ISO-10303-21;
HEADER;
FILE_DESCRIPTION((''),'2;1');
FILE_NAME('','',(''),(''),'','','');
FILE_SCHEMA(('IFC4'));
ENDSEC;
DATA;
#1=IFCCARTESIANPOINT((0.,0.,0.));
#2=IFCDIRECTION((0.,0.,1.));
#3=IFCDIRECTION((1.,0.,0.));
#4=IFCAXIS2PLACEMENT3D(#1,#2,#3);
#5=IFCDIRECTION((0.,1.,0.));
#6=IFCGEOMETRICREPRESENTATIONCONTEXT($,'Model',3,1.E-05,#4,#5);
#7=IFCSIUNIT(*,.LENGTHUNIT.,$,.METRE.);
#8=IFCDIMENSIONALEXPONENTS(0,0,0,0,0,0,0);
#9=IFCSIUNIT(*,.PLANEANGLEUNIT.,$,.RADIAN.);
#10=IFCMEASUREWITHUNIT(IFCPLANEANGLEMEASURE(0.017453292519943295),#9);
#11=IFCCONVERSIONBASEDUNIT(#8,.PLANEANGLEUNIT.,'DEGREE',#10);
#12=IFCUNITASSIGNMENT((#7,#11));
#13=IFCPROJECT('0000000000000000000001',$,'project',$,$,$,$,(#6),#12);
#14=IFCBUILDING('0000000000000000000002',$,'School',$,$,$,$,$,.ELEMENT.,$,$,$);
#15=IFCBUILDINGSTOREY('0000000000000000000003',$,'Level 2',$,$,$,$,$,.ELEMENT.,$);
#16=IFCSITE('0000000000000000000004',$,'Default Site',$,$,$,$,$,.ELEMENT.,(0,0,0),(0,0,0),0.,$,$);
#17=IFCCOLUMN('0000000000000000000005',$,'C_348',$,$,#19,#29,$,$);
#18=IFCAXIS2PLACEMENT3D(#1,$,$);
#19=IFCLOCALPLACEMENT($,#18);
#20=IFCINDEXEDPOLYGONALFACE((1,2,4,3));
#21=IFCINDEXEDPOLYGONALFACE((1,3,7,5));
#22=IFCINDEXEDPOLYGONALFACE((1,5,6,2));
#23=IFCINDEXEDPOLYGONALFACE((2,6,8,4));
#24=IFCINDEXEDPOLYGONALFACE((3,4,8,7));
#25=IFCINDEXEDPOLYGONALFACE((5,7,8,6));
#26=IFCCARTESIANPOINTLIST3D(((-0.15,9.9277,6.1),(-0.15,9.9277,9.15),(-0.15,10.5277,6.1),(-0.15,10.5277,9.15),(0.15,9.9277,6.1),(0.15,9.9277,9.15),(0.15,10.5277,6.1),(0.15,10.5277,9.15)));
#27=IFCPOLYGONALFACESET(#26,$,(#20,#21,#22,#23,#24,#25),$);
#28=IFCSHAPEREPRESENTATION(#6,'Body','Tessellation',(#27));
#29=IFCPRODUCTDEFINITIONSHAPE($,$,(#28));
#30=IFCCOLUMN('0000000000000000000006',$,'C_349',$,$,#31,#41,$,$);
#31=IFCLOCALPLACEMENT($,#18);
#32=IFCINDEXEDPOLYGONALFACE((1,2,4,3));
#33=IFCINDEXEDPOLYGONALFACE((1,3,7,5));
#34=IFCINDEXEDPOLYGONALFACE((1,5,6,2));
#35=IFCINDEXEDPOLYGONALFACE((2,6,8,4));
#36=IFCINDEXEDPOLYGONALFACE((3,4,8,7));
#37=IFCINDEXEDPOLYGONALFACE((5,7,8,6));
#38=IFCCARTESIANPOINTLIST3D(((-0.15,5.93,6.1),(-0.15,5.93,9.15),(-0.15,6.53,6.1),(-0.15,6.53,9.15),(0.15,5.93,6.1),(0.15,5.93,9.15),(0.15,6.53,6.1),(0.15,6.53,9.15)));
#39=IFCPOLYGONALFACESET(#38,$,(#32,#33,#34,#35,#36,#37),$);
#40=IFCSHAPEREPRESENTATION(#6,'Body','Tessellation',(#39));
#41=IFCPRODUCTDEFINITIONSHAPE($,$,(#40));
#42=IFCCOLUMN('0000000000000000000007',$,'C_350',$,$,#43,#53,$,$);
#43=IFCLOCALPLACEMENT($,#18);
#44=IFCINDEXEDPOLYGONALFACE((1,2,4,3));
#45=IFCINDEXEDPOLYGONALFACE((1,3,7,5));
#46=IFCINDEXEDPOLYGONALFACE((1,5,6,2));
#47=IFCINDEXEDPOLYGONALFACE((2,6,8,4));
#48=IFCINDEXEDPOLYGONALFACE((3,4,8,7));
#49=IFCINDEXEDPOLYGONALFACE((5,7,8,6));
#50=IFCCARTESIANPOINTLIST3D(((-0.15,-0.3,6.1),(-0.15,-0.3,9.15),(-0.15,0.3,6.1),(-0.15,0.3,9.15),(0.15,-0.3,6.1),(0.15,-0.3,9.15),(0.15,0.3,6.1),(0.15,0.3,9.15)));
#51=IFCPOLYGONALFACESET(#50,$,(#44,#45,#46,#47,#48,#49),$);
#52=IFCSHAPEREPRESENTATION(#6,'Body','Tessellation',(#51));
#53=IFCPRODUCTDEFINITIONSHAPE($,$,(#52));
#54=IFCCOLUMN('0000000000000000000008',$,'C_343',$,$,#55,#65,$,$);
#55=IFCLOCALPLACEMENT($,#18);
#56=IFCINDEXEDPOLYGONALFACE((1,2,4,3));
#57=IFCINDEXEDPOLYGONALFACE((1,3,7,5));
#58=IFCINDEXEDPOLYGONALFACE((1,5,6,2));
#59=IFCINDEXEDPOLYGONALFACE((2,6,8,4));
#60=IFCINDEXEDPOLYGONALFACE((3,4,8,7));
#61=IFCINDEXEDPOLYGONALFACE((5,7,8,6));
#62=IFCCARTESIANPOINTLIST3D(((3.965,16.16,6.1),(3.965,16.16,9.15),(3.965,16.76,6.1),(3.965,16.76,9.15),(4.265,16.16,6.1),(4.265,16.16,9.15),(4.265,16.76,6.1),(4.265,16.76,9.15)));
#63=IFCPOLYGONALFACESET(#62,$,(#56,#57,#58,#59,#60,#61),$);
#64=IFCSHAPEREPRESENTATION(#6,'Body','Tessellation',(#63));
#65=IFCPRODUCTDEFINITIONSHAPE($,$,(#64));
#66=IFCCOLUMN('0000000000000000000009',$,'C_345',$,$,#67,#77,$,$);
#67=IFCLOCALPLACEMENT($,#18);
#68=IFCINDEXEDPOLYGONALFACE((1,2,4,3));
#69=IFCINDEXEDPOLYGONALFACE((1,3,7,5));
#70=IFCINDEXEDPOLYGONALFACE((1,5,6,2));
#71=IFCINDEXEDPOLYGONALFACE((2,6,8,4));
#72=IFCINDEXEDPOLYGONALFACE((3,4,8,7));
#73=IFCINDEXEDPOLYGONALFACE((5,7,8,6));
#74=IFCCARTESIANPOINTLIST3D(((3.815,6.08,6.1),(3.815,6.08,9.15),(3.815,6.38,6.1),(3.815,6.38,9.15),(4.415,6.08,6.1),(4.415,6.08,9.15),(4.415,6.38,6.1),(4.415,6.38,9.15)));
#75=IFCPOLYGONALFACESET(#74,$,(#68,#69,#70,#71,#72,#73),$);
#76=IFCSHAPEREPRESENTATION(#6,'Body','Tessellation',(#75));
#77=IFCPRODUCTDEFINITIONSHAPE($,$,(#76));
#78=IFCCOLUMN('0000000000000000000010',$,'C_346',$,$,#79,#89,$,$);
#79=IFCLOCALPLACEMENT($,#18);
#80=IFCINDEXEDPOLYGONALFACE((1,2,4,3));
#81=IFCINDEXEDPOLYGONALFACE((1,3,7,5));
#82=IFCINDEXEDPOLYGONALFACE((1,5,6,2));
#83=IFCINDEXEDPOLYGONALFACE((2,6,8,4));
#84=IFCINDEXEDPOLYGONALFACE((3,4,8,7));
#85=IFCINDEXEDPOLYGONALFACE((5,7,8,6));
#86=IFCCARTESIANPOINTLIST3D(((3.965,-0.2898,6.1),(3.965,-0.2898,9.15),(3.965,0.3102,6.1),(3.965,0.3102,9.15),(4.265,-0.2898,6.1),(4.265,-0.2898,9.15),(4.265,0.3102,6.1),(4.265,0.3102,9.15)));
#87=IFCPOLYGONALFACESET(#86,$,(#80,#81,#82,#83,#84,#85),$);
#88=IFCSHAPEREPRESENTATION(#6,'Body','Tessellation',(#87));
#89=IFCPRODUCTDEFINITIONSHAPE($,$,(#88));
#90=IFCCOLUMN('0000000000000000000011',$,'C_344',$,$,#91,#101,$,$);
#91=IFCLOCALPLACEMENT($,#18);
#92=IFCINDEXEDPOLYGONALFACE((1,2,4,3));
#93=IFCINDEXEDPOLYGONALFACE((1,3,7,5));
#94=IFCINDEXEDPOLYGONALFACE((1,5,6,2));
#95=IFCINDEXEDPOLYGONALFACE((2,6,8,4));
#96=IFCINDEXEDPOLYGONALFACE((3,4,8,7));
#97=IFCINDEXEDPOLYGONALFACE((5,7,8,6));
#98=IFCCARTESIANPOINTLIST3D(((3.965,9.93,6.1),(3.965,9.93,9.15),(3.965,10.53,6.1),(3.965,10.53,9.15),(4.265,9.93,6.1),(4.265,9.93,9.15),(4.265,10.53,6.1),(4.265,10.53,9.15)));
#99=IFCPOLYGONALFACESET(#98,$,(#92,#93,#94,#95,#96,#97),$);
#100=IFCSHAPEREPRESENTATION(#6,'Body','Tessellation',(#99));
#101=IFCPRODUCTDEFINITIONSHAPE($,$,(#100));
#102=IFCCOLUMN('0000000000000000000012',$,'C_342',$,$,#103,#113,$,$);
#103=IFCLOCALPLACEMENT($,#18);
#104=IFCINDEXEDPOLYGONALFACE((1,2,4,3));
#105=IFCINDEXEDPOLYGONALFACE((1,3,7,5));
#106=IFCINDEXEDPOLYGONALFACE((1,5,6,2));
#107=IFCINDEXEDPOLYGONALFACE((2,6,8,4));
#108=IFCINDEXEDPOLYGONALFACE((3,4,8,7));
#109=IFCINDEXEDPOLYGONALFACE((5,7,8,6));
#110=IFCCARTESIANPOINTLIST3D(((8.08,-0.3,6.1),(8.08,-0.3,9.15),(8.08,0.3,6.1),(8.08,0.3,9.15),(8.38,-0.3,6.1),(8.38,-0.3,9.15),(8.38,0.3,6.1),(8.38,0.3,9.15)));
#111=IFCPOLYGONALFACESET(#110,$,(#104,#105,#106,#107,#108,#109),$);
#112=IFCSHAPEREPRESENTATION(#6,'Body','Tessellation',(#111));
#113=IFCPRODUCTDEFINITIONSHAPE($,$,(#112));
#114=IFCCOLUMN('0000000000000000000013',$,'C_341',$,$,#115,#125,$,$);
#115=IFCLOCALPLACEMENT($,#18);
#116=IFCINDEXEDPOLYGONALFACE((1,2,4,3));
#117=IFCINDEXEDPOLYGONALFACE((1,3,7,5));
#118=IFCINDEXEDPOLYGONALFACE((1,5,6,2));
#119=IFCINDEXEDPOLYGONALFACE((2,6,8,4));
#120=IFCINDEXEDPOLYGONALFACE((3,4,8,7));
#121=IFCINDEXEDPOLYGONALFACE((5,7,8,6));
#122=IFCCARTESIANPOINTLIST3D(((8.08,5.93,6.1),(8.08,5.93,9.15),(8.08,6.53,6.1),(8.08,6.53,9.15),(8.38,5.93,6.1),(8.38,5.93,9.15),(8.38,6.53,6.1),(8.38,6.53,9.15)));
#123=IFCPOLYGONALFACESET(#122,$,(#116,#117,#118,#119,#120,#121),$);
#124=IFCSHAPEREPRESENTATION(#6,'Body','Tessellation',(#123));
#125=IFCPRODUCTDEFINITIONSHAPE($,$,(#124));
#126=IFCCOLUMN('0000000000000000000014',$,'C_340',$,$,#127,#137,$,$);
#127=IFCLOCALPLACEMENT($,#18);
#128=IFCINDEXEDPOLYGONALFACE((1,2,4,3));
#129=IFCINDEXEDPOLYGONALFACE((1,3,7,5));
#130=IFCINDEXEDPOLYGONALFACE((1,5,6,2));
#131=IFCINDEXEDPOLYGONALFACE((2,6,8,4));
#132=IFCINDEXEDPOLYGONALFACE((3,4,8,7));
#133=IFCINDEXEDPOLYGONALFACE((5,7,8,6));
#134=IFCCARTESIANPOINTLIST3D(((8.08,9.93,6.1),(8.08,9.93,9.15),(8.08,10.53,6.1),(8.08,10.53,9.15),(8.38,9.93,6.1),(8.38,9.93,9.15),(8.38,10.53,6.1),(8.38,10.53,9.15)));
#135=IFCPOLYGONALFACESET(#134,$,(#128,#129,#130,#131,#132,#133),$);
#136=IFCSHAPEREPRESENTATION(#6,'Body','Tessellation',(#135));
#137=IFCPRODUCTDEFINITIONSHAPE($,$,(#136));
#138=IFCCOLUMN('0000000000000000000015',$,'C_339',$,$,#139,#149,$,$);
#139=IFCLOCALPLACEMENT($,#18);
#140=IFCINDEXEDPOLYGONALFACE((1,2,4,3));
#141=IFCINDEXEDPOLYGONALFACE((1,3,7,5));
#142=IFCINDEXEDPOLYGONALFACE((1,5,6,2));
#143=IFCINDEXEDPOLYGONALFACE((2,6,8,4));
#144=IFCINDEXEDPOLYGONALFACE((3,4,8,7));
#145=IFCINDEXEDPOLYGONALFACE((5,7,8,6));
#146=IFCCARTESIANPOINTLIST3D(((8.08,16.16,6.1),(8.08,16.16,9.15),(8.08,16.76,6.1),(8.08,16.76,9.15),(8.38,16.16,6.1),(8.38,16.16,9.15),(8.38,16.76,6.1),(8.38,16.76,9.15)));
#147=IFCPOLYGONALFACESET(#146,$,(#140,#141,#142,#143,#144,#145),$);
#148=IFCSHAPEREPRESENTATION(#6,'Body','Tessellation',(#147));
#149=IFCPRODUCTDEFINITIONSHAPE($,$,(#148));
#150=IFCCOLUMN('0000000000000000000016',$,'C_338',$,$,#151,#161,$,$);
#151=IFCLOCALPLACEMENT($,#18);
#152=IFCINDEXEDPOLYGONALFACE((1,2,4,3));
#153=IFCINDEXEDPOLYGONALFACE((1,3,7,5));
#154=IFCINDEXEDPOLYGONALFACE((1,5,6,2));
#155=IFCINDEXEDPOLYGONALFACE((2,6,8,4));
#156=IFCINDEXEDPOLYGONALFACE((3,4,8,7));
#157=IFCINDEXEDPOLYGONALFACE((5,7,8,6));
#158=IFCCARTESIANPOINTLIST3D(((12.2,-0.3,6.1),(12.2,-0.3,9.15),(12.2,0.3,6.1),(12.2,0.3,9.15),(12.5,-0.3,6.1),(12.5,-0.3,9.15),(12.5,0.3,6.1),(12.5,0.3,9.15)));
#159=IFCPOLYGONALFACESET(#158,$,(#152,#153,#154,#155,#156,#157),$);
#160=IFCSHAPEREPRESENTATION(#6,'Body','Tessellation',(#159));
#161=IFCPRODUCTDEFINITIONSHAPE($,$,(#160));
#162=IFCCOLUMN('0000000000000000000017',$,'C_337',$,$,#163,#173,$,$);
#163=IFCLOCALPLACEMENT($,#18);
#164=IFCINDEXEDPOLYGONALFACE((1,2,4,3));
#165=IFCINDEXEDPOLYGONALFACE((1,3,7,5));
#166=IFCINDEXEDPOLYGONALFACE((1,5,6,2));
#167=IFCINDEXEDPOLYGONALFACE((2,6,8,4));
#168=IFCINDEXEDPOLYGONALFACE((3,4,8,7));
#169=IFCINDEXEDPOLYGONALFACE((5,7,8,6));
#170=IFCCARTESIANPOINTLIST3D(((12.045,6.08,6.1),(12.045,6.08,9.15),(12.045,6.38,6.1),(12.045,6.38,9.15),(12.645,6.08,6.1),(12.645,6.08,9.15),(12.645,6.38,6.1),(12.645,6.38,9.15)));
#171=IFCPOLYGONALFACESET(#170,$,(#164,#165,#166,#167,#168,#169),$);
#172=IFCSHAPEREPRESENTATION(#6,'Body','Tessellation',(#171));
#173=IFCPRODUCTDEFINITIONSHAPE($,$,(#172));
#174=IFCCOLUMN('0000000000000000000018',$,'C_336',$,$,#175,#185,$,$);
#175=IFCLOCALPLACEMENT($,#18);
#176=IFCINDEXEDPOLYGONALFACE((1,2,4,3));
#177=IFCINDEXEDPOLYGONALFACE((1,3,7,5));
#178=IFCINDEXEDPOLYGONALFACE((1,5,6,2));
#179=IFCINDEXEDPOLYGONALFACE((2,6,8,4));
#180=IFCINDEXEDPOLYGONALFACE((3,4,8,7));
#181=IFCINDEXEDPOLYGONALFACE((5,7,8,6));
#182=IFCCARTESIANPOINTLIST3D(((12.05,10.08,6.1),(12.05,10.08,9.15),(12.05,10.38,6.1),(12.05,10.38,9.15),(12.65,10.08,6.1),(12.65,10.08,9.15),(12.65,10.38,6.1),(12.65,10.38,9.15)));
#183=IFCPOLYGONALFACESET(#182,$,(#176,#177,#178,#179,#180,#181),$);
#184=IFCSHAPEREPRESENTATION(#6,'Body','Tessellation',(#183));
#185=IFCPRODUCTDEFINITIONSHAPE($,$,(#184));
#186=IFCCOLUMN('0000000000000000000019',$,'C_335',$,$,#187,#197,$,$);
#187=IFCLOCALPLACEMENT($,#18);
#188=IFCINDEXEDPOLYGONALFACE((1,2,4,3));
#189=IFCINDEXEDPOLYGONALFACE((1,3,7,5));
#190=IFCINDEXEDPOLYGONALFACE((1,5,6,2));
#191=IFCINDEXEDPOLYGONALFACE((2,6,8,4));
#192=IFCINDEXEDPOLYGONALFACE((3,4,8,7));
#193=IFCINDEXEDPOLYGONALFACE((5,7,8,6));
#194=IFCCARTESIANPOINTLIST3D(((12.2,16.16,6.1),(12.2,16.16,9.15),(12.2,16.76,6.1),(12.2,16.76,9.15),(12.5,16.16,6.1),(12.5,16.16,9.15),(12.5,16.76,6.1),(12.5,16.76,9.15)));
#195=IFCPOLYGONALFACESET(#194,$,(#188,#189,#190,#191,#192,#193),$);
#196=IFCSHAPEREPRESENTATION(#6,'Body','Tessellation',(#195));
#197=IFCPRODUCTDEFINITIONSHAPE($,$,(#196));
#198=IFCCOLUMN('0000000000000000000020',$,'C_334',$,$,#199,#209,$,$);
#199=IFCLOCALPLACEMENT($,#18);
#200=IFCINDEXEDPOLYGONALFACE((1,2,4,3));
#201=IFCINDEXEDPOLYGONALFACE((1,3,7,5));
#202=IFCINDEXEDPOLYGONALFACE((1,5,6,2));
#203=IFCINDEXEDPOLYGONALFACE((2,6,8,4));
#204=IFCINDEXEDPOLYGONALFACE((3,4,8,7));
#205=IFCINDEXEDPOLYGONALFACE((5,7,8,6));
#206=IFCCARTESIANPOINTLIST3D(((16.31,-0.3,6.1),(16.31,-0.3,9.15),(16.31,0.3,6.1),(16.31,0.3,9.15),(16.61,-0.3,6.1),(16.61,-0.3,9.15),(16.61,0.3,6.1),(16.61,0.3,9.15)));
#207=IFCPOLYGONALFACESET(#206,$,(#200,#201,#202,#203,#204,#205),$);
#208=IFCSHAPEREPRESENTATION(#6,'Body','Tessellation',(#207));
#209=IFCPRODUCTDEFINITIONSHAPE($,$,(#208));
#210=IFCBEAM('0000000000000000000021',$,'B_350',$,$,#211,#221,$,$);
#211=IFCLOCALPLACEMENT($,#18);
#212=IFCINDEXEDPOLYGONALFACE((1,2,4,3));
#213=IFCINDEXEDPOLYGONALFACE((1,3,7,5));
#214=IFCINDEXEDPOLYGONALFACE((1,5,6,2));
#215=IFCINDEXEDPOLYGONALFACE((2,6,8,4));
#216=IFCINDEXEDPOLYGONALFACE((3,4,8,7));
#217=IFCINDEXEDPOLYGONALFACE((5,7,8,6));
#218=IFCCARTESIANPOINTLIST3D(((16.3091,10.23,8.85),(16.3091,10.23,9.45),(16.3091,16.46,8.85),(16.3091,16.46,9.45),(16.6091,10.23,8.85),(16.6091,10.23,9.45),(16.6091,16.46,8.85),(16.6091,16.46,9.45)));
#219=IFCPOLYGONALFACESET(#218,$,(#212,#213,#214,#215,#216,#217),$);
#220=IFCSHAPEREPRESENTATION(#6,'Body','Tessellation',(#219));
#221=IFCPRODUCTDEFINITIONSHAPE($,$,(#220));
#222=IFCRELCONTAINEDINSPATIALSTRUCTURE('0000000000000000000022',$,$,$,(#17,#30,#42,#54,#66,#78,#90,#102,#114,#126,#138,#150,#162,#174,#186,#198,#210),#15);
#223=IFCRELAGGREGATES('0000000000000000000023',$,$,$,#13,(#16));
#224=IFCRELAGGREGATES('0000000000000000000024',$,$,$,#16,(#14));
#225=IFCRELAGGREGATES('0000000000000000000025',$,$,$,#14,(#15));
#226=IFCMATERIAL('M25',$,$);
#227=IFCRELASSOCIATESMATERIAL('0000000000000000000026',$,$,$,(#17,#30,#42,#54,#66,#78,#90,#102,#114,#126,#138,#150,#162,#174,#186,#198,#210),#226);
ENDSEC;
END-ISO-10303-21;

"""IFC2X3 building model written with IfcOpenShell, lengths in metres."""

from ifc_helpers import new_model, entity, si_unit, converted_unit, direction, frame, frame_2d, origin_with_axes, place, context, project, spatial, rectangle, extrude, material, element, save


model = new_model("IFC2X3")

# Units and contexts
model_context = context("Model", 3, precision=1e-05, world=origin_with_axes(), true_north=direction((0.0, 1.0, 0.0)))
ifc_project = project(units=[si_unit("LENGTHUNIT", "METRE"), converted_unit("PLANEANGLEUNIT", "DEGREE", entity("IfcPlaneAngleMeasure", 0.017453292519943295), si_unit("PLANEANGLEUNIT", "RADIAN"), dimensions=[0, 0, 0, 0, 0, 0, 0])], contexts=[model_context])

# Site, building, storey
site = spatial("IfcSite", under=ifc_project, Name="Default Site", CompositionType="ELEMENT", RefLatitude=(0, 0, 0), RefLongitude=(0, 0, 0), RefElevation=0.0)
building = spatial("IfcBuilding", under=site, Name="School", CompositionType="ELEMENT")
storey = spatial("IfcBuildingStorey", under=building, Name="Level 2", CompositionType="ELEMENT")

# Columns
ifc_material = material(Name="M25")
placement = place(None, origin_with_axes())
element("IfcColumn", 1, at=placement, inside=storey, material=ifc_material, Name="C_348", context=model_context, shape_type="SweptSolid", body=[
    extrude(rectangle(XDim=0.3, YDim=0.6, at=frame_2d((0.0, 0.0), x_axis=(1.0, 0.0, 0.0))), frame((0.0, 10.2277, 6.1), z_axis=(0.0, 0.0, 1.0), x_axis=(1.0, 0.0, 0.0)), (0.0, 0.0, 1.0), 3.05),
])
element("IfcColumn", 2, at=placement, inside=storey, material=ifc_material, Name="C_349", context=model_context, shape_type="SweptSolid", body=[
    extrude(rectangle(XDim=0.3, YDim=0.6, at=frame_2d((0.0, 0.0), x_axis=(1.0, 0.0, 0.0))), frame((0.0, 6.23, 6.1), z_axis=(0.0, 0.0, 1.0), x_axis=(1.0, 0.0, 0.0)), (0.0, 0.0, 1.0), 3.05),
])
element("IfcColumn", 3, at=placement, inside=storey, material=ifc_material, Name="C_350", context=model_context, shape_type="SweptSolid", body=[
    extrude(rectangle(XDim=0.3, YDim=0.6, at=frame_2d((0.0, 0.0), x_axis=(1.0, 0.0, 0.0))), frame((0.0, 0.0, 6.1), z_axis=(0.0, 0.0, 1.0), x_axis=(1.0, 0.0, 0.0)), (0.0, 0.0, 1.0), 3.05),
])
element("IfcColumn", 4, at=placement, inside=storey, material=ifc_material, Name="C_343", context=model_context, shape_type="SweptSolid", body=[
    extrude(rectangle(XDim=0.3, YDim=0.6, at=frame_2d((0.0, 0.0), x_axis=(1.0, 0.0, 0.0))), frame((4.115, 16.46, 6.1), z_axis=(0.0, 0.0, 1.0), x_axis=(1.0, 0.0, 0.0)), (0.0, 0.0, 1.0), 3.05),
])
element("IfcColumn", 5, at=placement, inside=storey, material=ifc_material, Name="C_345", context=model_context, shape_type="SweptSolid", body=[
    extrude(rectangle(XDim=0.6, YDim=0.3, at=frame_2d((0.0, 0.0), x_axis=(1.0, 0.0, 0.0))), frame((4.115, 6.23, 6.1), z_axis=(0.0, 0.0, 1.0), x_axis=(1.0, 0.0, 0.0)), (0.0, 0.0, 1.0), 3.05),
])
element("IfcColumn", 6, at=placement, inside=storey, material=ifc_material, Name="C_346", context=model_context, shape_type="SweptSolid", body=[
    extrude(rectangle(XDim=0.3, YDim=0.6, at=frame_2d((0.0, 0.0), x_axis=(1.0, 0.0, 0.0))), frame((4.115, 0.0102, 6.1), z_axis=(0.0, 0.0, 1.0), x_axis=(1.0, 0.0, 0.0)), (0.0, 0.0, 1.0), 3.05),
])
element("IfcColumn", 7, at=placement, inside=storey, material=ifc_material, Name="C_344", context=model_context, shape_type="SweptSolid", body=[
    extrude(rectangle(XDim=0.3, YDim=0.6, at=frame_2d((0.0, 0.0), x_axis=(1.0, 0.0, 0.0))), frame((4.115, 10.23, 6.1), z_axis=(0.0, 0.0, 1.0), x_axis=(1.0, 0.0, 0.0)), (0.0, 0.0, 1.0), 3.05),
])
element("IfcColumn", 8, at=placement, inside=storey, material=ifc_material, Name="C_342", context=model_context, shape_type="SweptSolid", body=[
    extrude(rectangle(XDim=0.3, YDim=0.6, at=frame_2d((0.0, 0.0), x_axis=(1.0, 0.0, 0.0))), frame((8.23, 0.0, 6.1), z_axis=(0.0, 0.0, 1.0), x_axis=(1.0, 0.0, 0.0)), (0.0, 0.0, 1.0), 3.05),
])
element("IfcColumn", 9, at=placement, inside=storey, material=ifc_material, Name="C_341", context=model_context, shape_type="SweptSolid", body=[
    extrude(rectangle(XDim=0.3, YDim=0.6, at=frame_2d((0.0, 0.0), x_axis=(1.0, 0.0, 0.0))), frame((8.23, 6.23, 6.1), z_axis=(0.0, 0.0, 1.0), x_axis=(1.0, 0.0, 0.0)), (0.0, 0.0, 1.0), 3.05),
])
element("IfcColumn", 10, at=placement, inside=storey, material=ifc_material, Name="C_340", context=model_context, shape_type="SweptSolid", body=[
    extrude(rectangle(XDim=0.3, YDim=0.6, at=frame_2d((0.0, 0.0), x_axis=(1.0, 0.0, 0.0))), frame((8.23, 10.23, 6.1), z_axis=(0.0, 0.0, 1.0), x_axis=(1.0, 0.0, 0.0)), (0.0, 0.0, 1.0), 3.05),
])
element("IfcColumn", 11, at=placement, inside=storey, material=ifc_material, Name="C_339", context=model_context, shape_type="SweptSolid", body=[
    extrude(rectangle(XDim=0.3, YDim=0.6, at=frame_2d((0.0, 0.0), x_axis=(1.0, 0.0, 0.0))), frame((8.23, 16.46, 6.1), z_axis=(0.0, 0.0, 1.0), x_axis=(1.0, 0.0, 0.0)), (0.0, 0.0, 1.0), 3.05),
])
element("IfcColumn", 12, at=placement, inside=storey, material=ifc_material, Name="C_338", context=model_context, shape_type="SweptSolid", body=[
    extrude(rectangle(XDim=0.3, YDim=0.6, at=frame_2d((0.0, 0.0), x_axis=(1.0, 0.0, 0.0))), frame((12.35, 0.0, 6.1), z_axis=(0.0, 0.0, 1.0), x_axis=(1.0, 0.0, 0.0)), (0.0, 0.0, 1.0), 3.05),
])
element("IfcColumn", 13, at=placement, inside=storey, material=ifc_material, Name="C_337", context=model_context, shape_type="SweptSolid", body=[
    extrude(rectangle(XDim=0.6, YDim=0.3, at=frame_2d((0.0, 0.0), x_axis=(1.0, 0.0, 0.0))), frame((12.345, 6.23, 6.1), z_axis=(0.0, 0.0, 1.0), x_axis=(1.0, 0.0, 0.0)), (0.0, 0.0, 1.0), 3.05),
])
element("IfcColumn", 14, at=placement, inside=storey, material=ifc_material, Name="C_336", context=model_context, shape_type="SweptSolid", body=[
    extrude(rectangle(XDim=0.6, YDim=0.3, at=frame_2d((0.0, 0.0), x_axis=(1.0, 0.0, 0.0))), frame((12.35, 10.23, 6.1), z_axis=(0.0, 0.0, 1.0), x_axis=(1.0, 0.0, 0.0)), (0.0, 0.0, 1.0), 3.05),
])
element("IfcColumn", 15, at=placement, inside=storey, material=ifc_material, Name="C_335", context=model_context, shape_type="SweptSolid", body=[
    extrude(rectangle(XDim=0.3, YDim=0.6, at=frame_2d((0.0, 0.0), x_axis=(1.0, 0.0, 0.0))), frame((12.35, 16.46, 6.1), z_axis=(0.0, 0.0, 1.0), x_axis=(1.0, 0.0, 0.0)), (0.0, 0.0, 1.0), 3.05),
])
element("IfcColumn", 16, at=placement, inside=storey, material=ifc_material, Name="C_334", context=model_context, shape_type="SweptSolid", body=[
    extrude(rectangle(XDim=0.3, YDim=0.6, at=frame_2d((0.0, 0.0), x_axis=(1.0, 0.0, 0.0))), frame((16.46, 0.0, 6.1), z_axis=(0.0, 0.0, 1.0), x_axis=(1.0, 0.0, 0.0)), (0.0, 0.0, 1.0), 3.05),
])

# Beam
element("IfcBeam", 17, at=placement, inside=storey, material=ifc_material, Name="B_350", context=model_context, shape_type="SweptSolid", body=[
    extrude(rectangle(XDim=0.3, YDim=0.6, at=frame_2d((0.0, 0.0), x_axis=(0.0, 1.0, 0.0))), frame((16.4591, 10.23, 9.15), z_axis=(0.0, 1.0, 0.0), x_axis=(0.0, 0.0, -1.0)), (0.0, 0.0, 1.0), 6.23),
])

save(model, "model.ifc")
